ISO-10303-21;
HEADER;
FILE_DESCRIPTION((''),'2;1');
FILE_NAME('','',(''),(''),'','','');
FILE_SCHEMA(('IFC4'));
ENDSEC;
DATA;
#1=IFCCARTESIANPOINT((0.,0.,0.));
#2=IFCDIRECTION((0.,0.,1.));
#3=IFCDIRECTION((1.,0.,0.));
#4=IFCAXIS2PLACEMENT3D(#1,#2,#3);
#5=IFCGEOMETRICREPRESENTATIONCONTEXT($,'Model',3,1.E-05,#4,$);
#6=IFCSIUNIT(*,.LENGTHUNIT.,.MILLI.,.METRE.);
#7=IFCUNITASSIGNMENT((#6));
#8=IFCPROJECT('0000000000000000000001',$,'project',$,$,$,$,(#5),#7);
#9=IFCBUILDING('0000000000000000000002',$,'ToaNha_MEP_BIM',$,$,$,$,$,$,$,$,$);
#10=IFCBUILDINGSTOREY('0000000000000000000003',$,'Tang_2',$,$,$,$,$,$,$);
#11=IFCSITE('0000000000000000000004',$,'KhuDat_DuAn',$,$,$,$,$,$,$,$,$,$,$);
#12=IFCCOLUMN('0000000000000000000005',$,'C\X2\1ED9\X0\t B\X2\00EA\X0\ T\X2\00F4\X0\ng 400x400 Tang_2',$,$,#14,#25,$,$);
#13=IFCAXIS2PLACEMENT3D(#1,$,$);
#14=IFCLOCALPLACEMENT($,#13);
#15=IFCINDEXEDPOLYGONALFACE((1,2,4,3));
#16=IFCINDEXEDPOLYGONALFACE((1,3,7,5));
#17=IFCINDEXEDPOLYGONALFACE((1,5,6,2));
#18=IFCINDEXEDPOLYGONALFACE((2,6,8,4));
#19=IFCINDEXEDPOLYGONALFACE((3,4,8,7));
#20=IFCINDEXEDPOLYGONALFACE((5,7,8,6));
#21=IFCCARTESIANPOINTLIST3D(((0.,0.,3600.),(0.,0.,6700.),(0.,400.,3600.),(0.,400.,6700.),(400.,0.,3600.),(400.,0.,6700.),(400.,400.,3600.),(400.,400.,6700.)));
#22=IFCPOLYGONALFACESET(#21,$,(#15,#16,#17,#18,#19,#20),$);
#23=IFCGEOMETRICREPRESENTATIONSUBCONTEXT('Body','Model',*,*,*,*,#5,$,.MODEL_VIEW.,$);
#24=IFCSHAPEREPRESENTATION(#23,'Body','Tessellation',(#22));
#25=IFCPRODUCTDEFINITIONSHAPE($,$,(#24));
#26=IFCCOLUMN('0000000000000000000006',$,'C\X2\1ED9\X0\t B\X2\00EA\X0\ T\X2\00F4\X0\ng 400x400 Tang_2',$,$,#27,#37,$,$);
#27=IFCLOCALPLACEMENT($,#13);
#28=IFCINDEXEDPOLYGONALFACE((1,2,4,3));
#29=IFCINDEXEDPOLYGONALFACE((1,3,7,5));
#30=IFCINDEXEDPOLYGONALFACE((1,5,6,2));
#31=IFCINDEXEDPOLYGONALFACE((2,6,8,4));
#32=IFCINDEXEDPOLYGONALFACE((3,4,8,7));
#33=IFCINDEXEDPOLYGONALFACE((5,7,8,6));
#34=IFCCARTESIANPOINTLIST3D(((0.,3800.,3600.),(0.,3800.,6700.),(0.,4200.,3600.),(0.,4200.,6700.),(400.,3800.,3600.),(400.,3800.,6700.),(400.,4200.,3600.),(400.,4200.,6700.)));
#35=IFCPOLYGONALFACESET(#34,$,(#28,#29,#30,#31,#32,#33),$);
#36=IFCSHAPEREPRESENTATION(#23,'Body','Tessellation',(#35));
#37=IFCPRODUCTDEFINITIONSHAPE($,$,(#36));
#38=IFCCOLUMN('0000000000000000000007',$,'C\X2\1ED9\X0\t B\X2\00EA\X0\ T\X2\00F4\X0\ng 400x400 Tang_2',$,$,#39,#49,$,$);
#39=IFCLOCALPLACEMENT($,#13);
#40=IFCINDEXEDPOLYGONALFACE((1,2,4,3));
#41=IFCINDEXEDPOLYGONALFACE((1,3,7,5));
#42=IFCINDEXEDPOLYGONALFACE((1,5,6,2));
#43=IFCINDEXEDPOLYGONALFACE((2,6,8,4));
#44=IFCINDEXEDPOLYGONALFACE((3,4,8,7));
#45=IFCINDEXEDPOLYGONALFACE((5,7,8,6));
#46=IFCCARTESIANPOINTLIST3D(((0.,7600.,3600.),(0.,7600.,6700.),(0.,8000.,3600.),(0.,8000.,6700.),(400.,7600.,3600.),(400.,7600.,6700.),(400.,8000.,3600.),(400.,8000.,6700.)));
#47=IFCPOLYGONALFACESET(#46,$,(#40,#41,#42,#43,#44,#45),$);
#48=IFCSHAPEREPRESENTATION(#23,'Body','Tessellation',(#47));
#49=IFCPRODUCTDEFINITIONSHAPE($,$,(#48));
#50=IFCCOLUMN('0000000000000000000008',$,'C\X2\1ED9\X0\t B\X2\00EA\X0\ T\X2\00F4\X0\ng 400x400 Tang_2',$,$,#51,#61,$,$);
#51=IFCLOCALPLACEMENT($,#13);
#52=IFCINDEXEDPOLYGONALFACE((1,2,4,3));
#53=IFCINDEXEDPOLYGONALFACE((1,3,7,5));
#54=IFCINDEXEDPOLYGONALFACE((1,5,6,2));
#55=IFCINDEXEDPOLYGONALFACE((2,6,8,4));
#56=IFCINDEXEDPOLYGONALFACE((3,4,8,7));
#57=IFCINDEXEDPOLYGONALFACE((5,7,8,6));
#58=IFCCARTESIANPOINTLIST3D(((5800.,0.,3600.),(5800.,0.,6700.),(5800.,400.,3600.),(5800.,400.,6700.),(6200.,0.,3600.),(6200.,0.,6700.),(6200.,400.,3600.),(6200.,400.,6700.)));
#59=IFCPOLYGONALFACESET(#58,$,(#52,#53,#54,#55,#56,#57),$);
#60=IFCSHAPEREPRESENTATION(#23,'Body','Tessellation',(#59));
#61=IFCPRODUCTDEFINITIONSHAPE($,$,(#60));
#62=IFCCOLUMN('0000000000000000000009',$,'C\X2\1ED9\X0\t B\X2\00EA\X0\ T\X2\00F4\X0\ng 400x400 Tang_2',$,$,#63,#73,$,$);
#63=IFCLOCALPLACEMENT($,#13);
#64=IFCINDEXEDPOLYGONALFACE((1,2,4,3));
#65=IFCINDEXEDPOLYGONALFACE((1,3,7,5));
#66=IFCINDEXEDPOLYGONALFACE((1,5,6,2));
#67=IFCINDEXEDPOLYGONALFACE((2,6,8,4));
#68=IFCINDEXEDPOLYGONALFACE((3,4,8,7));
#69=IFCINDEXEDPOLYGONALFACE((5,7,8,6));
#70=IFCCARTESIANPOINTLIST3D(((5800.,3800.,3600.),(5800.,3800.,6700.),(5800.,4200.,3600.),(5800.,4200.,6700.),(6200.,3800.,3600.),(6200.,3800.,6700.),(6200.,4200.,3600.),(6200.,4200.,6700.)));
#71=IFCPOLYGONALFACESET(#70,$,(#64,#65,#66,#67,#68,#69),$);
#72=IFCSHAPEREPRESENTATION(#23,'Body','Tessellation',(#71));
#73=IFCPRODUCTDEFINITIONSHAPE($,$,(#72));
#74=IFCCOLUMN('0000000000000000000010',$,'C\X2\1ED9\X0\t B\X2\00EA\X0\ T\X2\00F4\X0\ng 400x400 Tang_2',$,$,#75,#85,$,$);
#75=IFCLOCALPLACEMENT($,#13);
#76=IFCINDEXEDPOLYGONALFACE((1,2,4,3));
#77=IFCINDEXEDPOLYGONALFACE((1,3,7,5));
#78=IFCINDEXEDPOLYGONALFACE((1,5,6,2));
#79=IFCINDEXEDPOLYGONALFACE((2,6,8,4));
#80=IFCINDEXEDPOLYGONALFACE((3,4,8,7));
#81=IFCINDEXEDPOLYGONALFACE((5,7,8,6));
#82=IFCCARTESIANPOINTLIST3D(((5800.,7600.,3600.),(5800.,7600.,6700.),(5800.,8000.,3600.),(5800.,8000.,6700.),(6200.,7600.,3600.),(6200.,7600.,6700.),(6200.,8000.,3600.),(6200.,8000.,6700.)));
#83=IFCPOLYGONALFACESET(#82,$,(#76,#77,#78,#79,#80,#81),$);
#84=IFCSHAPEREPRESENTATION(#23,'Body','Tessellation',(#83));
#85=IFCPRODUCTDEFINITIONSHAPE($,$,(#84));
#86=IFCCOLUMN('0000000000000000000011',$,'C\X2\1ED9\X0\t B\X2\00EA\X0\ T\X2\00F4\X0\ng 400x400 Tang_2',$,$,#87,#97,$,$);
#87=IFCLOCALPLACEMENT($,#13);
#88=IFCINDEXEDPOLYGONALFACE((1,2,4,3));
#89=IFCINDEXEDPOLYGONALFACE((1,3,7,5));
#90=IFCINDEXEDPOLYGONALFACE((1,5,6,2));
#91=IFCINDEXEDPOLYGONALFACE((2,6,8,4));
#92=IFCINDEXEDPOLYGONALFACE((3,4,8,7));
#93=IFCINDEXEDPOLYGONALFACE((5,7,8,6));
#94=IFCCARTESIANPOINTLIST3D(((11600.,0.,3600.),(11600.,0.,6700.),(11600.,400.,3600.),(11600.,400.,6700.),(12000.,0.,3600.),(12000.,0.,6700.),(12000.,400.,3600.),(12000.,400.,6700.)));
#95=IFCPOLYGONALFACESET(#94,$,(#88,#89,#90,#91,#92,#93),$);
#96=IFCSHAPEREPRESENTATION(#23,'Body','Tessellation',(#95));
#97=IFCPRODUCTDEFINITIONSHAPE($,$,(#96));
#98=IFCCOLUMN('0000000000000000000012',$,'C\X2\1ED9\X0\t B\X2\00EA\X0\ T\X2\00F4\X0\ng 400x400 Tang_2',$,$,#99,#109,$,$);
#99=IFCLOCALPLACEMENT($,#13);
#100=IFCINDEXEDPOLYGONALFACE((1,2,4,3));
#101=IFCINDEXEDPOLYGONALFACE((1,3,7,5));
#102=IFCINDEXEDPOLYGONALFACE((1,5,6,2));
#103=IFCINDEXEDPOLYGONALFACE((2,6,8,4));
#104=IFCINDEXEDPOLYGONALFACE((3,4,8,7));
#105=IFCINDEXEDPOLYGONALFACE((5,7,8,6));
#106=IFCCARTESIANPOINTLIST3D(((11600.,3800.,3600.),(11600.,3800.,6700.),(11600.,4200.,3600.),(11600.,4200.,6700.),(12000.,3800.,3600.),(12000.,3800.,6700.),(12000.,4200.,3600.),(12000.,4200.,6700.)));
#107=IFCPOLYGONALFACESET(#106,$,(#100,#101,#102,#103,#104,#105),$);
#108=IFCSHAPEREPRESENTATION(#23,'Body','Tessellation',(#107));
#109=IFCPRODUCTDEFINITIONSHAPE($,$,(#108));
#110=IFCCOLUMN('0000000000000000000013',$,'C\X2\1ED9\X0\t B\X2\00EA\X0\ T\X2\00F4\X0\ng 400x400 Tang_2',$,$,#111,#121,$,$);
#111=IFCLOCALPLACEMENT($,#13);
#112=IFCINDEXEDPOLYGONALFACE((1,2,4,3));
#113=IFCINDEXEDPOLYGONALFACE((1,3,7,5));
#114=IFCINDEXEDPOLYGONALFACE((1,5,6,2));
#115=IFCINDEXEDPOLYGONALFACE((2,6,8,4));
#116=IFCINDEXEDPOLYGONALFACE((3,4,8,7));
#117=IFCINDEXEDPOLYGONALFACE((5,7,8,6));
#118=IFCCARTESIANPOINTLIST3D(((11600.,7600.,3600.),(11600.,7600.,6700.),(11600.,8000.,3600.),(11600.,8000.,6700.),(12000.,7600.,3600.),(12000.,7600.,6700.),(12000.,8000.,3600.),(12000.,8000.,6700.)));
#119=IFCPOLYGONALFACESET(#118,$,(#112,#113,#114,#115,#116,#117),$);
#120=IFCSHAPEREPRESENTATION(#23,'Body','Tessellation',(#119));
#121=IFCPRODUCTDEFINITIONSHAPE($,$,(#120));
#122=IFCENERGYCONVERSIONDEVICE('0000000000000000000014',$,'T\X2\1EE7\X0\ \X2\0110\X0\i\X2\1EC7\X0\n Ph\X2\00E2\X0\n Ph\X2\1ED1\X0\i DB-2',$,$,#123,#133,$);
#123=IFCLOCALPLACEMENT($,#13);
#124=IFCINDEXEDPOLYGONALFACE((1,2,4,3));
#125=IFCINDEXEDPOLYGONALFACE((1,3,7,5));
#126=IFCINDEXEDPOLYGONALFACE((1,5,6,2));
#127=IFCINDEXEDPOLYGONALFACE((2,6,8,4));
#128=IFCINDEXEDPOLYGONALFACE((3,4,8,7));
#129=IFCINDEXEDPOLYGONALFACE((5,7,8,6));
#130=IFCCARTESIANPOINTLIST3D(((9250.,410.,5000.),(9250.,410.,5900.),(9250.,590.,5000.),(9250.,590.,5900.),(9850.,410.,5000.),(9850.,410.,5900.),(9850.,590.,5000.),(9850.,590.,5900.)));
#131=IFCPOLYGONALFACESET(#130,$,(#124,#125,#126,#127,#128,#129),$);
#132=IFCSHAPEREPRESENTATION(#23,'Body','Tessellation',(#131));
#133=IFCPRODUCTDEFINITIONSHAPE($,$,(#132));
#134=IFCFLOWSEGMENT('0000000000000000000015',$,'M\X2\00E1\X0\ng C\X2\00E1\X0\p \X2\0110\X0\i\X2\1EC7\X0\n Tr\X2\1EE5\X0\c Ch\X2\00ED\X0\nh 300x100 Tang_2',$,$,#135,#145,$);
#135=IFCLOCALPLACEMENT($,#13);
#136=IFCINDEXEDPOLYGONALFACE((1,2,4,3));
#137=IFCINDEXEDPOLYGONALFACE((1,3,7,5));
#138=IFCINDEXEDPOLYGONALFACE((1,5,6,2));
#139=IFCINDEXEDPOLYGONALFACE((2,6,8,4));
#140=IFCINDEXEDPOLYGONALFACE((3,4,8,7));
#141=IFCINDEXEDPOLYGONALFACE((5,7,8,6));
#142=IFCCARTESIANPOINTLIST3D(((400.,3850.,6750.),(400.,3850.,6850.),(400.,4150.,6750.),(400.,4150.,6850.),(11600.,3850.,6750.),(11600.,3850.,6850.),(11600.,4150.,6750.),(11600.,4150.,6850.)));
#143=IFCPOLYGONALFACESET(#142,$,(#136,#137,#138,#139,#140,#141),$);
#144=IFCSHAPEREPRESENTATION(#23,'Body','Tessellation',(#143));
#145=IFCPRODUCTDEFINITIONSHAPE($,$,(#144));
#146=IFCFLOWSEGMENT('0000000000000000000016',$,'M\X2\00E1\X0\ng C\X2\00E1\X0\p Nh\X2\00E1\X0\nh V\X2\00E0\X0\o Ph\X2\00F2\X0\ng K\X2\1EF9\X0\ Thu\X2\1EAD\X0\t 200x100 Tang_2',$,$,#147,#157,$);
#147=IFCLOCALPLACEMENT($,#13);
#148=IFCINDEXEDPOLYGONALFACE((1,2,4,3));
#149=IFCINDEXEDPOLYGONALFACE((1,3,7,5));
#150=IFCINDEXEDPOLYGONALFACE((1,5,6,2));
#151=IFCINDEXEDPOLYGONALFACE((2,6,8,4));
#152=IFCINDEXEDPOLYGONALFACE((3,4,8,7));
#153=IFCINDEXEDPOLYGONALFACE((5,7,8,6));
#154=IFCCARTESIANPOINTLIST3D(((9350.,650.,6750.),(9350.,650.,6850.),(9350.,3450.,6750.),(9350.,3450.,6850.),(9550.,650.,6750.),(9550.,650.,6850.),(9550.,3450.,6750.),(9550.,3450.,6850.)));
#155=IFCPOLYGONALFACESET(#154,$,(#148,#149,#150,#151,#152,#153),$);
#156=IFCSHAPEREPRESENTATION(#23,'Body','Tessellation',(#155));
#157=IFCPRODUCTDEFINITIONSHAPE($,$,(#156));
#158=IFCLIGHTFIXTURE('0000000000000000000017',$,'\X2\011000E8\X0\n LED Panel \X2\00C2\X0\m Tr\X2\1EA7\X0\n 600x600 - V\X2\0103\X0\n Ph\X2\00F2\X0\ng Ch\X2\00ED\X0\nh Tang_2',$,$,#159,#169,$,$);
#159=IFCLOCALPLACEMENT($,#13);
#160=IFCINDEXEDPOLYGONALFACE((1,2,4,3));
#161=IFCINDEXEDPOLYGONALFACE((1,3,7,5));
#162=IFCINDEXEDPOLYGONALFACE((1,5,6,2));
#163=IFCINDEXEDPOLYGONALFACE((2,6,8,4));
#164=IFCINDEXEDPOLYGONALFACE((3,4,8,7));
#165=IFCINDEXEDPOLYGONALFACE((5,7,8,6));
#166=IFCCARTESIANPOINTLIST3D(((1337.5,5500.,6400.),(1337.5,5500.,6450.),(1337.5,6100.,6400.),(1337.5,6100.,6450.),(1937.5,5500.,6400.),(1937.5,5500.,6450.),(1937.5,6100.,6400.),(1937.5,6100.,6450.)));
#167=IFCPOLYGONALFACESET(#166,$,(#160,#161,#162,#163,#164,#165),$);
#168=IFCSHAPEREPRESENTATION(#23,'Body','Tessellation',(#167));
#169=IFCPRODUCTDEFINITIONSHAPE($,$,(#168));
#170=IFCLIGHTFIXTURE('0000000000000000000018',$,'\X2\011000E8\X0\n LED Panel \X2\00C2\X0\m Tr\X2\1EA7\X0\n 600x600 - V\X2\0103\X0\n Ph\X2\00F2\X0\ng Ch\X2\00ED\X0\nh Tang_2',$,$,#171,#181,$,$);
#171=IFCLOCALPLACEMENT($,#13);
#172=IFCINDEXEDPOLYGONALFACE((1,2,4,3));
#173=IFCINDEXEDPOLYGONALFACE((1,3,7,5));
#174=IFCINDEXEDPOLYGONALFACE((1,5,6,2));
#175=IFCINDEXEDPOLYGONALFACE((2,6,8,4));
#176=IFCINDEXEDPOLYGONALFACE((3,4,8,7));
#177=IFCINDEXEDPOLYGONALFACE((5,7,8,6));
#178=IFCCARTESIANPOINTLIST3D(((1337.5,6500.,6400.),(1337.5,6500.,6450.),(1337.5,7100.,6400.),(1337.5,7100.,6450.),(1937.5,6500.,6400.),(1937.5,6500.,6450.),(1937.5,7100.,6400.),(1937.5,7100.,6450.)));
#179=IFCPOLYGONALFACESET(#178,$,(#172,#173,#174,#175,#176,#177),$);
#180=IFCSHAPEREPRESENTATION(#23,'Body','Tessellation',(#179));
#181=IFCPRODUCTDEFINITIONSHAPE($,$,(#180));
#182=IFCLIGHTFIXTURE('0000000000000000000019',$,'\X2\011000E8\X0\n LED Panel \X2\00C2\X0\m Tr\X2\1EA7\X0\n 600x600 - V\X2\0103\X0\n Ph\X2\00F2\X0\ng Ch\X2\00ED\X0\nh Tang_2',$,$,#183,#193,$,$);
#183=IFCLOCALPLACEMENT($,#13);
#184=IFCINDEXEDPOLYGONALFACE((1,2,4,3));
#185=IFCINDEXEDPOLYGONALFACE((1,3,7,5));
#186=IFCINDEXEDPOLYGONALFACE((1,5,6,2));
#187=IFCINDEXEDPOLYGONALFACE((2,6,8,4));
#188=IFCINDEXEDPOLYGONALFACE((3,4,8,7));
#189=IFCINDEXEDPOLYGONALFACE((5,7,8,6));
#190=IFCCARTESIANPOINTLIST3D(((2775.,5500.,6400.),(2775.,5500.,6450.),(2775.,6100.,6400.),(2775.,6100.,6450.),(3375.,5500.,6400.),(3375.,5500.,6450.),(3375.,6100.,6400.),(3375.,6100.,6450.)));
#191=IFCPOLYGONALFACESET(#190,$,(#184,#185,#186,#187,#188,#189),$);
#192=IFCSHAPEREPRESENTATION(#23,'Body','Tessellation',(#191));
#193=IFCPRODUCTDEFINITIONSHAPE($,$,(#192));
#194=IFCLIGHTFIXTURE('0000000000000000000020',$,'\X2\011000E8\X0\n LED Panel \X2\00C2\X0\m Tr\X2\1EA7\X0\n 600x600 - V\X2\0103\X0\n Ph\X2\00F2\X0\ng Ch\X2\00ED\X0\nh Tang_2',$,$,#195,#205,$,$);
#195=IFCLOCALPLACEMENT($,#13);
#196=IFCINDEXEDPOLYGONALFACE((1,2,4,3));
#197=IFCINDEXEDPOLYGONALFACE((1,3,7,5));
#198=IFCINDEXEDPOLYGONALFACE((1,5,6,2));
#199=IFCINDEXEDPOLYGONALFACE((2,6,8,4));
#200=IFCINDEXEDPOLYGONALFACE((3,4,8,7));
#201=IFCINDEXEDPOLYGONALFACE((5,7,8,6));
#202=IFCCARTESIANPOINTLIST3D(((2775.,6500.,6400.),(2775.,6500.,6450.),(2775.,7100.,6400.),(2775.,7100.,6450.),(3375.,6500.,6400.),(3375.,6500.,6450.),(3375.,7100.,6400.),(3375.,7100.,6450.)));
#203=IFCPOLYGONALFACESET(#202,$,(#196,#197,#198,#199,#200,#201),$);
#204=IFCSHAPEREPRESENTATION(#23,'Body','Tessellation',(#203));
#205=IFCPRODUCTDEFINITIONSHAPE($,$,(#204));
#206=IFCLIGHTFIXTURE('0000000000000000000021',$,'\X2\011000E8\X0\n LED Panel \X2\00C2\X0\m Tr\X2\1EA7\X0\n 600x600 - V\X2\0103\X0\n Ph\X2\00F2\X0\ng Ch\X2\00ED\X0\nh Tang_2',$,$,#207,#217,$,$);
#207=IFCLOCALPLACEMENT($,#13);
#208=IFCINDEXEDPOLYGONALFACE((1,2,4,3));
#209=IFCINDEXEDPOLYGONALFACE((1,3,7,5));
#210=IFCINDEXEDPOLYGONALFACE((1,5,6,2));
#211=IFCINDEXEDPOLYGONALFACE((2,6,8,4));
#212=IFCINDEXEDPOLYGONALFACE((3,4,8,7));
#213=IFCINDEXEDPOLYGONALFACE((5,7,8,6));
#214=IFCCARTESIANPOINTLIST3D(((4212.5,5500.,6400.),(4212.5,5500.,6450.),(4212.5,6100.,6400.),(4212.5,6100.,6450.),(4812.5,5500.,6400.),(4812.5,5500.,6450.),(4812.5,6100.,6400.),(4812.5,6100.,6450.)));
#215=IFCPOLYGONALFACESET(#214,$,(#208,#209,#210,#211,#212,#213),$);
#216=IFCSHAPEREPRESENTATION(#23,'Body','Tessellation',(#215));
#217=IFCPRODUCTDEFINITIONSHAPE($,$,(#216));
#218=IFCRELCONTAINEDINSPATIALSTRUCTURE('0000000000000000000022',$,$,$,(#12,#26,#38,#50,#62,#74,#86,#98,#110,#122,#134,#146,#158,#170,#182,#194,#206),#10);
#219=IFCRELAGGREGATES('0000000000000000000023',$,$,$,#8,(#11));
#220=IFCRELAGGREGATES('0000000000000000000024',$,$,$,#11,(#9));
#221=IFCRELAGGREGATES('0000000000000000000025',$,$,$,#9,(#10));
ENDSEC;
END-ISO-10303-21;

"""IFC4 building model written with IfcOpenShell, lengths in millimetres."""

from ifc_helpers import new_model, si_unit, frame, origin_with_axes, context, subcontext, project, spatial, polyline, outline, extrude, element, save


model = new_model("IFC4")

# Units and contexts
model_context = context("Model", 3, precision=1e-05, world=origin_with_axes())
body_context = subcontext(model_context, "Body", "Model", "MODEL_VIEW")
ifc_project = project(units=[si_unit("LENGTHUNIT", "METRE", prefix="MILLI")], contexts=[model_context])

# Site, building, storey
site = spatial("IfcSite", under=ifc_project, Name="KhuDat_DuAn")
building = spatial("IfcBuilding", under=site, Name="ToaNha_MEP_BIM")
storey = spatial("IfcBuildingStorey", under=building, Name="Tang_2")

# Columns
element("IfcColumn", 1, inside=storey, Name="Cột Bê Tông 400x400 Tang_2", context=body_context, shape_type="SweptSolid", body=[
    extrude(outline(polyline([(0.0, 0.0), (400.0, 0.0), (400.0, 400.0), (0.0, 400.0), (0.0, 0.0)])), frame((0.0, 0.0, 3600.0), z_axis=(0.0, 0.0, 1.0), x_axis=(1.0, 0.0, 0.0)), (0.0, 0.0, 1.0), 3100.0),
])
element("IfcColumn", 2, inside=storey, Name="Cột Bê Tông 400x400 Tang_2", context=body_context, shape_type="SweptSolid", body=[
    extrude(outline(polyline([(0.0, 3800.0), (400.0, 3800.0), (400.0, 4200.0), (0.0, 4200.0), (0.0, 3800.0)])), frame((0.0, 0.0, 3600.0), z_axis=(0.0, 0.0, 1.0), x_axis=(1.0, 0.0, 0.0)), (0.0, 0.0, 1.0), 3100.0),
])
element("IfcColumn", 3, inside=storey, Name="Cột Bê Tông 400x400 Tang_2", context=body_context, shape_type="SweptSolid", body=[
    extrude(outline(polyline([(0.0, 7600.0), (400.0, 7600.0), (400.0, 8000.0), (0.0, 8000.0), (0.0, 7600.0)])), frame((0.0, 0.0, 3600.0), z_axis=(0.0, 0.0, 1.0), x_axis=(1.0, 0.0, 0.0)), (0.0, 0.0, 1.0), 3100.0),
])
element("IfcColumn", 4, inside=storey, Name="Cột Bê Tông 400x400 Tang_2", context=body_context, shape_type="SweptSolid", body=[
    extrude(outline(polyline([(5800.0, 0.0), (6200.0, 0.0), (6200.0, 400.0), (5800.0, 400.0), (5800.0, 0.0)])), frame((0.0, 0.0, 3600.0), z_axis=(0.0, 0.0, 1.0), x_axis=(1.0, 0.0, 0.0)), (0.0, 0.0, 1.0), 3100.0),
])
element("IfcColumn", 5, inside=storey, Name="Cột Bê Tông 400x400 Tang_2", context=body_context, shape_type="SweptSolid", body=[
    extrude(outline(polyline([(5800.0, 3800.0), (6200.0, 3800.0), (6200.0, 4200.0), (5800.0, 4200.0), (5800.0, 3800.0)])), frame((0.0, 0.0, 3600.0), z_axis=(0.0, 0.0, 1.0), x_axis=(1.0, 0.0, 0.0)), (0.0, 0.0, 1.0), 3100.0),
])
element("IfcColumn", 6, inside=storey, Name="Cột Bê Tông 400x400 Tang_2", context=body_context, shape_type="SweptSolid", body=[
    extrude(outline(polyline([(5800.0, 7600.0), (6200.0, 7600.0), (6200.0, 8000.0), (5800.0, 8000.0), (5800.0, 7600.0)])), frame((0.0, 0.0, 3600.0), z_axis=(0.0, 0.0, 1.0), x_axis=(1.0, 0.0, 0.0)), (0.0, 0.0, 1.0), 3100.0),
])
element("IfcColumn", 7, inside=storey, Name="Cột Bê Tông 400x400 Tang_2", context=body_context, shape_type="SweptSolid", body=[
    extrude(outline(polyline([(11600.0, 0.0), (12000.0, 0.0), (12000.0, 400.0), (11600.0, 400.0), (11600.0, 0.0)])), frame((0.0, 0.0, 3600.0), z_axis=(0.0, 0.0, 1.0), x_axis=(1.0, 0.0, 0.0)), (0.0, 0.0, 1.0), 3100.0),
])
element("IfcColumn", 8, inside=storey, Name="Cột Bê Tông 400x400 Tang_2", context=body_context, shape_type="SweptSolid", body=[
    extrude(outline(polyline([(11600.0, 3800.0), (12000.0, 3800.0), (12000.0, 4200.0), (11600.0, 4200.0), (11600.0, 3800.0)])), frame((0.0, 0.0, 3600.0), z_axis=(0.0, 0.0, 1.0), x_axis=(1.0, 0.0, 0.0)), (0.0, 0.0, 1.0), 3100.0),
])
element("IfcColumn", 9, inside=storey, Name="Cột Bê Tông 400x400 Tang_2", context=body_context, shape_type="SweptSolid", body=[
    extrude(outline(polyline([(11600.0, 7600.0), (12000.0, 7600.0), (12000.0, 8000.0), (11600.0, 8000.0), (11600.0, 7600.0)])), frame((0.0, 0.0, 3600.0), z_axis=(0.0, 0.0, 1.0), x_axis=(1.0, 0.0, 0.0)), (0.0, 0.0, 1.0), 3100.0),
])

# Energy conversion device
element("IfcEnergyConversionDevice", 10, inside=storey, Name="Tủ Điện Phân Phối DB-2", context=body_context, shape_type="SweptSolid", body=[
    extrude(outline(polyline([(9250.0, 410.0), (9850.0, 410.0), (9850.0, 590.0), (9250.0, 590.0), (9250.0, 410.0)])), frame((0.0, 0.0, 5000.0), z_axis=(0.0, 0.0, 1.0), x_axis=(1.0, 0.0, 0.0)), (0.0, 0.0, 1.0), 900.0),
])

# Flow segments
element("IfcFlowSegment", 11, inside=storey, Name="Máng Cáp Điện Trục Chính 300x100 Tang_2", context=body_context, shape_type="SweptSolid", body=[
    extrude(outline(polyline([(400.0, 3850.0), (11600.0, 3850.0), (11600.0, 4150.0), (400.0, 4150.0), (400.0, 3850.0)])), frame((0.0, 0.0, 6750.0), z_axis=(0.0, 0.0, 1.0), x_axis=(1.0, 0.0, 0.0)), (0.0, 0.0, 1.0), 100.0),
])
element("IfcFlowSegment", 12, inside=storey, Name="Máng Cáp Nhánh Vào Phòng Kỹ Thuật 200x100 Tang_2", context=body_context, shape_type="SweptSolid", body=[
    extrude(outline(polyline([(9350.0, 650.0), (9550.0, 650.0), (9550.0, 3450.0), (9350.0, 3450.0), (9350.0, 650.0)])), frame((0.0, 0.0, 6750.0), z_axis=(0.0, 0.0, 1.0), x_axis=(1.0, 0.0, 0.0)), (0.0, 0.0, 1.0), 100.0),
])

# Light fixtures
element("IfcLightFixture", 13, inside=storey, Name="Đèn LED Panel Âm Trần 600x600 - Văn Phòng Chính Tang_2", context=body_context, shape_type="SweptSolid", body=[
    extrude(outline(polyline([(1337.5, 5500.0), (1937.5, 5500.0), (1937.5, 6100.0), (1337.5, 6100.0), (1337.5, 5500.0)])), frame((0.0, 0.0, 6400.0), z_axis=(0.0, 0.0, 1.0), x_axis=(1.0, 0.0, 0.0)), (0.0, 0.0, 1.0), 50.0),
])
element("IfcLightFixture", 14, inside=storey, Name="Đèn LED Panel Âm Trần 600x600 - Văn Phòng Chính Tang_2", context=body_context, shape_type="SweptSolid", body=[
    extrude(outline(polyline([(1337.5, 6500.0), (1937.5, 6500.0), (1937.5, 7100.0), (1337.5, 7100.0), (1337.5, 6500.0)])), frame((0.0, 0.0, 6400.0), z_axis=(0.0, 0.0, 1.0), x_axis=(1.0, 0.0, 0.0)), (0.0, 0.0, 1.0), 50.0),
])
element("IfcLightFixture", 15, inside=storey, Name="Đèn LED Panel Âm Trần 600x600 - Văn Phòng Chính Tang_2", context=body_context, shape_type="SweptSolid", body=[
    extrude(outline(polyline([(2775.0, 5500.0), (3375.0, 5500.0), (3375.0, 6100.0), (2775.0, 6100.0), (2775.0, 5500.0)])), frame((0.0, 0.0, 6400.0), z_axis=(0.0, 0.0, 1.0), x_axis=(1.0, 0.0, 0.0)), (0.0, 0.0, 1.0), 50.0),
])
element("IfcLightFixture", 16, inside=storey, Name="Đèn LED Panel Âm Trần 600x600 - Văn Phòng Chính Tang_2", context=body_context, shape_type="SweptSolid", body=[
    extrude(outline(polyline([(2775.0, 6500.0), (3375.0, 6500.0), (3375.0, 7100.0), (2775.0, 7100.0), (2775.0, 6500.0)])), frame((0.0, 0.0, 6400.0), z_axis=(0.0, 0.0, 1.0), x_axis=(1.0, 0.0, 0.0)), (0.0, 0.0, 1.0), 50.0),
])
element("IfcLightFixture", 17, inside=storey, Name="Đèn LED Panel Âm Trần 600x600 - Văn Phòng Chính Tang_2", context=body_context, shape_type="SweptSolid", body=[
    extrude(outline(polyline([(4212.5, 5500.0), (4812.5, 5500.0), (4812.5, 6100.0), (4212.5, 6100.0), (4212.5, 5500.0)])), frame((0.0, 0.0, 6400.0), z_axis=(0.0, 0.0, 1.0), x_axis=(1.0, 0.0, 0.0)), (0.0, 0.0, 1.0), 50.0),
])

save(model, "model.ifc")
